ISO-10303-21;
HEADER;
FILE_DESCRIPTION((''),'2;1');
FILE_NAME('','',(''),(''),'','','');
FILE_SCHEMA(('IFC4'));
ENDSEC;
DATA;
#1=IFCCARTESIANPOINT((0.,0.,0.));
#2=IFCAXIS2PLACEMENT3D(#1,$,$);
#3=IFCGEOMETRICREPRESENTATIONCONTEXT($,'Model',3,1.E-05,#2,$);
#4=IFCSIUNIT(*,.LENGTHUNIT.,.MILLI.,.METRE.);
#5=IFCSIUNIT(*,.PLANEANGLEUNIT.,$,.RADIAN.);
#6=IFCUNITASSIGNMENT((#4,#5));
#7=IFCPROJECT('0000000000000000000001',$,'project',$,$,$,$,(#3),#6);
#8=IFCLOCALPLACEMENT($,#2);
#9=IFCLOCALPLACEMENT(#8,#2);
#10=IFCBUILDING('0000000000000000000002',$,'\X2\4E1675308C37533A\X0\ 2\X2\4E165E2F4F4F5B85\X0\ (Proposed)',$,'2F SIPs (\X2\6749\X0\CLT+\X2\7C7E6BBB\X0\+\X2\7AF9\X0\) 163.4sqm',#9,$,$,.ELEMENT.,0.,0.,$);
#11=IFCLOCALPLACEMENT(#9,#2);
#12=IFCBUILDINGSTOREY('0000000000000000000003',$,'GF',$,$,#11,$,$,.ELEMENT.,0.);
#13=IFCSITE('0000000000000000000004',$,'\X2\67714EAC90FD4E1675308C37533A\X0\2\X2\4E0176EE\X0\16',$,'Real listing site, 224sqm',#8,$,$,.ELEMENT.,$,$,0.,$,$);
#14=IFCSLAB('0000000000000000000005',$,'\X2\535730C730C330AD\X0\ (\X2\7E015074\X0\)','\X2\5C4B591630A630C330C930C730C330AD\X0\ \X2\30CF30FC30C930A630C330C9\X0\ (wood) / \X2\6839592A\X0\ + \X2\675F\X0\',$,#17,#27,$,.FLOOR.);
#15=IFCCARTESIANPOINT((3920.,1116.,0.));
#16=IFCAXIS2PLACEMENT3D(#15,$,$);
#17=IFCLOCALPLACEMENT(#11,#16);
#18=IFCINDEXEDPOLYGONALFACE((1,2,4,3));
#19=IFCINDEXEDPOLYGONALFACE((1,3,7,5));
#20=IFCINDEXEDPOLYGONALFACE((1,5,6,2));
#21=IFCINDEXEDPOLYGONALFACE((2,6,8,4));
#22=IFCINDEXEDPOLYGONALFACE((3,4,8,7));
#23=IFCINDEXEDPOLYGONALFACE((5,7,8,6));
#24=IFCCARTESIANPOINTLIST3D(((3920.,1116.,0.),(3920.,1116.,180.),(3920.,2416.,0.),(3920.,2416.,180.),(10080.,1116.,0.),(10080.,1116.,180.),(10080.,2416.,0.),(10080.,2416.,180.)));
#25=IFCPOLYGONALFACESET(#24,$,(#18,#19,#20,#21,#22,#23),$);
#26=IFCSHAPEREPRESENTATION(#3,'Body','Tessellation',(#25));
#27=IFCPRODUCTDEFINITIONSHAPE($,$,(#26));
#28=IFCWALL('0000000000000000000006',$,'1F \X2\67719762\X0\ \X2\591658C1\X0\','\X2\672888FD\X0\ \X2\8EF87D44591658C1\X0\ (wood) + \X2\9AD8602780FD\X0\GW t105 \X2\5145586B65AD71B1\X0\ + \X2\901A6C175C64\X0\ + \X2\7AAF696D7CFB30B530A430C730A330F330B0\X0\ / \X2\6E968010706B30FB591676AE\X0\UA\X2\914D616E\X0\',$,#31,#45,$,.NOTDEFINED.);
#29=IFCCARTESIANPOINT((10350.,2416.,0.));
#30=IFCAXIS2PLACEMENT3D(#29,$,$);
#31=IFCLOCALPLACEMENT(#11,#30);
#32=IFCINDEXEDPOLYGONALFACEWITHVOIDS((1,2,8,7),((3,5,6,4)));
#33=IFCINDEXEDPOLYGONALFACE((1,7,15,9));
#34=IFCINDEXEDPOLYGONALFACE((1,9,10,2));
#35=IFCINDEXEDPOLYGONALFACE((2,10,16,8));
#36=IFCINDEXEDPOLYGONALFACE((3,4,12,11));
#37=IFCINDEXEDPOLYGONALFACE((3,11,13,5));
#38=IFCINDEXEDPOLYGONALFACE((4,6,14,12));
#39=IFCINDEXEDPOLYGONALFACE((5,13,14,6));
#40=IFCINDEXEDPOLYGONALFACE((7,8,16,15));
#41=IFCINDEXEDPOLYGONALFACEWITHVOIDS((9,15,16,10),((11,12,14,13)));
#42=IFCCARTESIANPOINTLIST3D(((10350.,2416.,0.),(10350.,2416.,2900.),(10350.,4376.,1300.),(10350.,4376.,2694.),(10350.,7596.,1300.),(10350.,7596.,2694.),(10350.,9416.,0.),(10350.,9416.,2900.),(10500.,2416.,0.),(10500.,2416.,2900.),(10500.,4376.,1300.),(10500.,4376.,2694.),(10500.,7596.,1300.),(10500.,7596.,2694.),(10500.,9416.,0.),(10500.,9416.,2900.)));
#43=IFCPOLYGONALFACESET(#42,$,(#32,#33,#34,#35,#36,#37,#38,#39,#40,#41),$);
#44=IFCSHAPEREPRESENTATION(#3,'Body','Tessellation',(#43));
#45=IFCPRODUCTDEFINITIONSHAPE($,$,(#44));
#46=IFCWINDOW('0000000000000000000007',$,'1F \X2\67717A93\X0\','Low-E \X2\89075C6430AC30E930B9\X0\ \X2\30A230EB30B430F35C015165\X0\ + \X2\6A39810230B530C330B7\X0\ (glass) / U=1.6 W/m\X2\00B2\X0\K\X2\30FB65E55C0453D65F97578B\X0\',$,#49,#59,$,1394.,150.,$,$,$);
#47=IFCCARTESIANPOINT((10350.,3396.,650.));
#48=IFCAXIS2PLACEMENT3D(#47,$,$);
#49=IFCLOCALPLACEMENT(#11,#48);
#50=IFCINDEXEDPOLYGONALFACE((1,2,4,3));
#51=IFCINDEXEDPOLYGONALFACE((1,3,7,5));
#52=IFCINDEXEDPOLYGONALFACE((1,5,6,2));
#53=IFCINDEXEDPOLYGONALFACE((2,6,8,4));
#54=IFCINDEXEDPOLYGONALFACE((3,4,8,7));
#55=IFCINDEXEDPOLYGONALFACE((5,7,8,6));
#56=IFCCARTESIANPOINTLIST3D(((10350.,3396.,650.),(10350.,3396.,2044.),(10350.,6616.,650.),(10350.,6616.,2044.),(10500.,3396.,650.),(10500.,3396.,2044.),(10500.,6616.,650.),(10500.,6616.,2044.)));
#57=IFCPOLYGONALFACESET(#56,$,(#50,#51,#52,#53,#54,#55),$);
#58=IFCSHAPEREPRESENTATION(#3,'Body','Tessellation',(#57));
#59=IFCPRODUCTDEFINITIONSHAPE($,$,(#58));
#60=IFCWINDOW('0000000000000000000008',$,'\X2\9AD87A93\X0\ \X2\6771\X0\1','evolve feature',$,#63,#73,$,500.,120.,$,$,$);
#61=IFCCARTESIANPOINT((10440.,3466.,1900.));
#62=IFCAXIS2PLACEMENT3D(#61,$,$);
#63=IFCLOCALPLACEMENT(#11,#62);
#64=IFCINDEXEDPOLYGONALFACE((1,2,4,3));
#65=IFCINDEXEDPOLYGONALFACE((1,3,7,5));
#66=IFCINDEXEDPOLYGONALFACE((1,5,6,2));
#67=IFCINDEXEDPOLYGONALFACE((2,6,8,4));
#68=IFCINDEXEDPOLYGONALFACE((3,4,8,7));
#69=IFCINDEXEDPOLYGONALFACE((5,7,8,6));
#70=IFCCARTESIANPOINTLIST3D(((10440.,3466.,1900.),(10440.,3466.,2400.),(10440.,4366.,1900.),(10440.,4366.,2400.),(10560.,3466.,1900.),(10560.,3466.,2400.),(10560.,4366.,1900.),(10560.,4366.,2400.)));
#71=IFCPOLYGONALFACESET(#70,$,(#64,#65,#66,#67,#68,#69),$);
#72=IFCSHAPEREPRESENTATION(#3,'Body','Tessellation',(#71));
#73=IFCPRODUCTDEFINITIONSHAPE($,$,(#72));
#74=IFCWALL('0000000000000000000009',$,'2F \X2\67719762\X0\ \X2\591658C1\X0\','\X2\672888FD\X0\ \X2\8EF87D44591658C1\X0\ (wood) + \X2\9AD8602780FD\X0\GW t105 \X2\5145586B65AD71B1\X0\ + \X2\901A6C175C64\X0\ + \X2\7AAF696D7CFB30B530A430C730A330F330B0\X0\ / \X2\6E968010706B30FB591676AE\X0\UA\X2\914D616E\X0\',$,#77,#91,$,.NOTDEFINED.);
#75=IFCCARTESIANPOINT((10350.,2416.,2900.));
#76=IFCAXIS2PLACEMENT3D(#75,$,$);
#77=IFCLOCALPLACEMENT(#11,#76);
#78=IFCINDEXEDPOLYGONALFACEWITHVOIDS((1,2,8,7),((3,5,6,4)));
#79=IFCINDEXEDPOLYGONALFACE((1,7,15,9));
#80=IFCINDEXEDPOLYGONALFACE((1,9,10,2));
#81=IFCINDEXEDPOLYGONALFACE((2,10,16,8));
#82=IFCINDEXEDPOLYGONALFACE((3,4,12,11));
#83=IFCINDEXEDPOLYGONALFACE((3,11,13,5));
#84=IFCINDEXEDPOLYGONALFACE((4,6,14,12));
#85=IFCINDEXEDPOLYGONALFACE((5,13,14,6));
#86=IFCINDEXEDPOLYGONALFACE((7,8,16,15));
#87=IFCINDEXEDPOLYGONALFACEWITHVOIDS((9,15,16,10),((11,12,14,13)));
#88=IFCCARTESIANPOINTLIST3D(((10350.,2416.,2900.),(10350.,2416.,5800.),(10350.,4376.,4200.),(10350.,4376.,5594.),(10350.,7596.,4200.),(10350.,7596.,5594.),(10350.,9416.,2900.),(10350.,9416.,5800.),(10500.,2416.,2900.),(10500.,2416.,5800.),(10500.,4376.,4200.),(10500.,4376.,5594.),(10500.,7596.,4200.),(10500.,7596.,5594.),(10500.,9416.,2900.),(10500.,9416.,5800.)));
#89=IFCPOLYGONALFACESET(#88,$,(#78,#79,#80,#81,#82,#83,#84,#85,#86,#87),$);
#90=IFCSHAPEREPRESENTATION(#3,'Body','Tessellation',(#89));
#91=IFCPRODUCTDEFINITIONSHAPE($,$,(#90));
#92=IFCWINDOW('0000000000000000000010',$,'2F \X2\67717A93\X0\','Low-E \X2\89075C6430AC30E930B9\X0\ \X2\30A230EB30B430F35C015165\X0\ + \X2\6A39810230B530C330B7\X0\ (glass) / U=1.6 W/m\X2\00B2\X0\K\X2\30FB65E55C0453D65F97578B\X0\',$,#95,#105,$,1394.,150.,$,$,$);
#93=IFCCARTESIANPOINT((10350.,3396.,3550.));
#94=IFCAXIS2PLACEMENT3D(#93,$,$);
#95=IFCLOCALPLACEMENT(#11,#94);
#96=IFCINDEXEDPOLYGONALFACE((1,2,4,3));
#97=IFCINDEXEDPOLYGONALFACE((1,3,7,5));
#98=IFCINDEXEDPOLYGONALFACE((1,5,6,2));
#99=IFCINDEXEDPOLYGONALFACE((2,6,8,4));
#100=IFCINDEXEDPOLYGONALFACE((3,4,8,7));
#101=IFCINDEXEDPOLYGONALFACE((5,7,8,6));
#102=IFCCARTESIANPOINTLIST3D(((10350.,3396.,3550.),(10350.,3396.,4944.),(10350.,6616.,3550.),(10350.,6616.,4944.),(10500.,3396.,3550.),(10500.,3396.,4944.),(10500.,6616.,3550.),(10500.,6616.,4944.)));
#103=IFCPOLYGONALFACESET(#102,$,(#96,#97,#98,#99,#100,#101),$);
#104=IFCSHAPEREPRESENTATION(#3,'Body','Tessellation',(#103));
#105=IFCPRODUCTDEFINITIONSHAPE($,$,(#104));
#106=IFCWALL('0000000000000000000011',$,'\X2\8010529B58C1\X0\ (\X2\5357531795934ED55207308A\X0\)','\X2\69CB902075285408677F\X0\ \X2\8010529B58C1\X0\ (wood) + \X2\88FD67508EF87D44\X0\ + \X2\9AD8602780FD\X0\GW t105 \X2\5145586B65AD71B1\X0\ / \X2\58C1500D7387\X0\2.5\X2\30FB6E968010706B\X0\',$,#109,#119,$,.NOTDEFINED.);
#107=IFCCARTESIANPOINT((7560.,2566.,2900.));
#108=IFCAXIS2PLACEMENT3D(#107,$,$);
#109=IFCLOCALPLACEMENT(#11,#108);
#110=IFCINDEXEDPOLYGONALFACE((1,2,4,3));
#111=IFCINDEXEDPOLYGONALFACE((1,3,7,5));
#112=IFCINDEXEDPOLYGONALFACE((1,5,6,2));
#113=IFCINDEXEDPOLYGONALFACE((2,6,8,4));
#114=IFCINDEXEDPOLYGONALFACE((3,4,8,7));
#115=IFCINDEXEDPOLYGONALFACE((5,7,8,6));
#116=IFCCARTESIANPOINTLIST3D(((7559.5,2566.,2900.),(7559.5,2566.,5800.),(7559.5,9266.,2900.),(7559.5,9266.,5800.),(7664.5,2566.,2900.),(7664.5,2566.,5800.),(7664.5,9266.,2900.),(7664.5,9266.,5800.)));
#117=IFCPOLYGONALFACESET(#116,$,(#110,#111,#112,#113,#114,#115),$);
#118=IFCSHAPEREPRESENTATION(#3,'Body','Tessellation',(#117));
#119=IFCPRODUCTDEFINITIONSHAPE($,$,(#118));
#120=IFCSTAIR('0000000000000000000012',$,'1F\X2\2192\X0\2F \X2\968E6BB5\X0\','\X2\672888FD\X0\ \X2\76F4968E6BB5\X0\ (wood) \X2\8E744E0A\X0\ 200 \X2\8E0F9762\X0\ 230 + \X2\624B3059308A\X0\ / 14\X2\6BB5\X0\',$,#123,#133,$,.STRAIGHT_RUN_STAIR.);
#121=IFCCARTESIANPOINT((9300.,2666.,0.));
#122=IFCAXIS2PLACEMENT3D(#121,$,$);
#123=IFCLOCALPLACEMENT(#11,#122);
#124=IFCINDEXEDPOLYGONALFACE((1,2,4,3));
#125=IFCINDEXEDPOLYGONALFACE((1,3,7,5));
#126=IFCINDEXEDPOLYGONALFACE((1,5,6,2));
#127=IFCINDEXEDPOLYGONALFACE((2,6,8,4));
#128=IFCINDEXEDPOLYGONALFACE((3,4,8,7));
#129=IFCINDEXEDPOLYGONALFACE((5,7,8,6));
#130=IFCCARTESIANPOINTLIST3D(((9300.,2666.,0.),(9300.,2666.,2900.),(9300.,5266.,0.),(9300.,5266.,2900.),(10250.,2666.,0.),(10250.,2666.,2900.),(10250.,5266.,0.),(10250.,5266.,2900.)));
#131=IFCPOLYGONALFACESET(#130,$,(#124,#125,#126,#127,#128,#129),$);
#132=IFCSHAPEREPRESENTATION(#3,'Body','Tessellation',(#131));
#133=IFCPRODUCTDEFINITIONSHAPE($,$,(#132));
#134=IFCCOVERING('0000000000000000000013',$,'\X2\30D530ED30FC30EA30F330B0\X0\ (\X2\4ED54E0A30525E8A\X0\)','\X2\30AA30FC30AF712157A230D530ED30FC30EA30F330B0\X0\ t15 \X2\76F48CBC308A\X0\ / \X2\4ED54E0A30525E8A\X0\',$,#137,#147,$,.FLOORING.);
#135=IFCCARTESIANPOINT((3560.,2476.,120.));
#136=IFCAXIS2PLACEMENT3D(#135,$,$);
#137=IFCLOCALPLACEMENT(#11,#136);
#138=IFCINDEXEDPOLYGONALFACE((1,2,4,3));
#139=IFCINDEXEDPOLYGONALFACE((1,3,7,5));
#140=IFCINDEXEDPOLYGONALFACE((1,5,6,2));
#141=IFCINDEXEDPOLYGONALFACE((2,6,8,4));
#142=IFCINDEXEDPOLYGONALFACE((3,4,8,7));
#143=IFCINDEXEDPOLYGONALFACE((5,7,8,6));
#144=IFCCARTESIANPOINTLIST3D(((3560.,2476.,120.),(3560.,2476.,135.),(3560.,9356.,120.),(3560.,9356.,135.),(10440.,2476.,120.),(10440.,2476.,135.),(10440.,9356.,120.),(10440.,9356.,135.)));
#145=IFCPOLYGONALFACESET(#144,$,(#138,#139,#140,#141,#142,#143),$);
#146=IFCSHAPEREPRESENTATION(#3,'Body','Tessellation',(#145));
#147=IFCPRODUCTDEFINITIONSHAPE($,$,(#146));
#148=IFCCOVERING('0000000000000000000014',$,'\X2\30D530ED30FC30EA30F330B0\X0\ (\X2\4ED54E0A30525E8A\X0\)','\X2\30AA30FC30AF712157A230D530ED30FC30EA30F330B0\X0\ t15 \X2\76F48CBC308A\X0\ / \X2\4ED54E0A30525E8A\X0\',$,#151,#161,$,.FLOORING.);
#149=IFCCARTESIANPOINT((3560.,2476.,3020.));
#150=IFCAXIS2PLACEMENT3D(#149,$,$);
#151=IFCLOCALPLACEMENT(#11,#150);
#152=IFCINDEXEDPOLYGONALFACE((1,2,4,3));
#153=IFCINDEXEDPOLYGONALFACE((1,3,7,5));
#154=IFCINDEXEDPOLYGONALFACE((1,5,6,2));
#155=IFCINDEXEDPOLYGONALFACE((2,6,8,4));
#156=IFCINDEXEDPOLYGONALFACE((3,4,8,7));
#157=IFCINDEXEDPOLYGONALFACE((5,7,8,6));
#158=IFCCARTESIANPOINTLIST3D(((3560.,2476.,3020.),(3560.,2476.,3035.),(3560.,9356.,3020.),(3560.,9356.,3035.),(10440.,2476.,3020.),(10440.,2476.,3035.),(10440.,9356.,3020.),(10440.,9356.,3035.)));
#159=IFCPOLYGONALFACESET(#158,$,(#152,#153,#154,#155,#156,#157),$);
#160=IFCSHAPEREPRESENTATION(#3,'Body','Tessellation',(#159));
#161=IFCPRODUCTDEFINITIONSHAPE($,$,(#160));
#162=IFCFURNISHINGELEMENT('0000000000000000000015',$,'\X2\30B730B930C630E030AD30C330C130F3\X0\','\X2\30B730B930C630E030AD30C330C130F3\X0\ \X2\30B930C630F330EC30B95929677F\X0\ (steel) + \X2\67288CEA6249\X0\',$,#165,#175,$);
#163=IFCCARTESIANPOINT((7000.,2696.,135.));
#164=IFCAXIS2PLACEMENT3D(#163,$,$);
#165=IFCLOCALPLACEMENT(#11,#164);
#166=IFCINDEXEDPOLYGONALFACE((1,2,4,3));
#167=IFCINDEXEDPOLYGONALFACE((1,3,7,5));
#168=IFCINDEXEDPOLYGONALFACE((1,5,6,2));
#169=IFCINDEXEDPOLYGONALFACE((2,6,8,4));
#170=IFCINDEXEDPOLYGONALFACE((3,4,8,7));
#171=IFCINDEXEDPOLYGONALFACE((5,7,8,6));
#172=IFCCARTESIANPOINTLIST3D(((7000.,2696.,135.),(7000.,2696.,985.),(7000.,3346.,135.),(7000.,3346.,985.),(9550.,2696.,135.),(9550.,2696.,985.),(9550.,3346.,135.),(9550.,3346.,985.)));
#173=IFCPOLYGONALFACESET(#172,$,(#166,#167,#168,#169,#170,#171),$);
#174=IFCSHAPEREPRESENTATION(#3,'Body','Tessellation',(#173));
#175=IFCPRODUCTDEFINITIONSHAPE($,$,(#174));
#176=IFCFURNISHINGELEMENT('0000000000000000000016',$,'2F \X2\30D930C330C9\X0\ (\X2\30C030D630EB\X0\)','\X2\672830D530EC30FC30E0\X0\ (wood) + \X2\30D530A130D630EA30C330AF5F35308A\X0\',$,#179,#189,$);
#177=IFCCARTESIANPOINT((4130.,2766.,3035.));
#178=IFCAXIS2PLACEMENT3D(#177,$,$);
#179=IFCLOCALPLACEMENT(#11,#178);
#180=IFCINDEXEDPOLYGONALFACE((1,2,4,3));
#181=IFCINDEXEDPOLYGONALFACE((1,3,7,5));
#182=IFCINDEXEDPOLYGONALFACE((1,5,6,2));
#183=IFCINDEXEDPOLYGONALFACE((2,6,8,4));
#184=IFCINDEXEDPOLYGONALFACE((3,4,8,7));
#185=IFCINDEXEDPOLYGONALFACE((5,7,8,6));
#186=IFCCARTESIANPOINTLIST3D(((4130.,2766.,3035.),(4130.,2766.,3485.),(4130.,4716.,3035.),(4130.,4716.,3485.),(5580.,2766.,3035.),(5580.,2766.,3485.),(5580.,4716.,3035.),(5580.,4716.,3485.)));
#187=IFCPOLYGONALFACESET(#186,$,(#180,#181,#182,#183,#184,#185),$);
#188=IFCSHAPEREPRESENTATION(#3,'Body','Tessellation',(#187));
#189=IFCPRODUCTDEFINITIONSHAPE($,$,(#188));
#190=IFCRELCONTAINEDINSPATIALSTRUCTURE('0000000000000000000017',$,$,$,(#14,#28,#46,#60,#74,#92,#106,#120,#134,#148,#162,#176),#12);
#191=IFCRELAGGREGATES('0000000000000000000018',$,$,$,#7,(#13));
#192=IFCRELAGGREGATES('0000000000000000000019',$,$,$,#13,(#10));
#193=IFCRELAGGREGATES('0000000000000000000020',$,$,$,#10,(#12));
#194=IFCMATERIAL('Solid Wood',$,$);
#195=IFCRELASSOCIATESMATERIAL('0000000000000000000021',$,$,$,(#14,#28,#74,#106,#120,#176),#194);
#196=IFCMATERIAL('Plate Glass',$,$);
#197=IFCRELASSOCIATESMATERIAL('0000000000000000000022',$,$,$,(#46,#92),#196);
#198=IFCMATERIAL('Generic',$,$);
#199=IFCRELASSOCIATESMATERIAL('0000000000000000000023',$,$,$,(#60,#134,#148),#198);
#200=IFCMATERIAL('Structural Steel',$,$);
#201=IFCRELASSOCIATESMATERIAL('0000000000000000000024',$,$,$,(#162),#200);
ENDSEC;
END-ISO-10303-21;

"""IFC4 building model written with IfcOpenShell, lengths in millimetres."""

from ifc_helpers import new_model, si_unit, frame, frame_2d, origin, place, context, project, spatial, rectangle, extrude, material, element, fill, save


model = new_model("IFC4")

# Units and contexts
model_context = context("Model", 3, precision=1e-05, world=origin())
ifc_project = project(units=[si_unit("LENGTHUNIT", "METRE", prefix="MILLI"), si_unit("PLANEANGLEUNIT", "RADIAN")], contexts=[model_context])

# Site, building, storey
site_placement = place(None, origin())
site = spatial("IfcSite", under=ifc_project, at=site_placement, Name="東京都世田谷区2丁目16", ObjectType="Real listing site, 224sqm", CompositionType="ELEMENT", RefElevation=0.0)
building_placement = place(site_placement, origin())
building = spatial("IfcBuilding", under=site, at=building_placement, Name="世田谷区 2世帯住宅 (Proposed)", ObjectType="2F SIPs (杉CLT+籾殻+竹) 163.4sqm", CompositionType="ELEMENT", ElevationOfRefHeight=0.0, ElevationOfTerrain=0.0)
storey_placement = place(building_placement, origin())
storey = spatial("IfcBuildingStorey", under=building, at=storey_placement, Name="GF", CompositionType="ELEMENT", Elevation=0.0)

# Slab
ifc_material_1 = material(Name="Solid Wood")
slab_placement = place(storey_placement, frame((3920.0, 1116.0, 0.0)))
element("IfcSlab", 1, at=slab_placement, inside=storey, material=ifc_material_1, Name="南デッキ (縁側)", Description="屋外ウッドデッキ ハードウッド (wood) / 根太 + 束", PredefinedType="FLOOR", context=model_context, shape_type="SweptSolid", body=[
    extrude(rectangle(XDim=6160.0, YDim=1300.0, at=frame_2d((3080.0, 650.0))), frame((3920.0, 1116.0, 0.0)), (0.0, 0.0, 1.0), 180.0),
])

# Wall, openings, windows
wall_1_placement = place(storey_placement, frame((10350.0, 2416.0, 0.0)))
wall_1 = element("IfcWall", 2, at=wall_1_placement, inside=storey, material=ifc_material_1, Name="1F 東面 外壁", Description="木製 軸組外壁 (wood) + 高性能GW t105 充填断熱 + 通気層 + 窯業系サイディング / 準耐火・外皮UA配慮", PredefinedType="NOTDEFINED", context=model_context, shape_type="SweptSolid", body=[
    extrude(rectangle(XDim=150.0, YDim=7000.0, at=frame_2d((75.0, 3500.0))), frame((10350.0, 2416.0, 0.0)), (0.0, 0.0, 1.0), 2900.0),
])
opening_1_placement = place(storey_placement, frame((10350.0, 3396.0, 650.0)))
opening_1 = element("IfcOpeningElement", 3, at=opening_1_placement, cuts=wall_1, PredefinedType="NOTDEFINED", context=model_context, shape_type="SweptSolid", body=[
    extrude(rectangle(XDim=150.0, YDim=3220.0, at=frame_2d((75.0, 1610.0))), frame((10350.0, 3396.0, 650.0)), (0.0, 0.0, 1.0), 1394.0),
])
opening_2_placement = place(storey_placement, frame((10440.0, 3466.0, 1900.0)))
opening_2 = element("IfcOpeningElement", 4, at=opening_2_placement, cuts=wall_1, PredefinedType="NOTDEFINED", context=model_context, shape_type="SweptSolid", body=[
    extrude(rectangle(XDim=120.0, YDim=900.0, at=frame_2d((60.0, 450.0))), frame((10440.0, 3466.0, 1900.0)), (0.0, 0.0, 1.0), 500.0),
])
ifc_material_2 = material(Name="Plate Glass")
window_1_placement = place(storey_placement, frame((10350.0, 3396.0, 650.0)))
window_1 = element("IfcWindow", 5, at=window_1_placement, inside=storey, material=ifc_material_2, Name="1F 東窓", Description="Low-E 複層ガラス アルゴン封入 + 樹脂サッシ (glass) / U=1.6 W/m²K・日射取得型", OverallHeight=1394.0, OverallWidth=150.0, context=model_context, shape_type="SweptSolid", body=[
    extrude(rectangle(XDim=150.0, YDim=3220.0, at=frame_2d((75.0, 1610.0))), frame((10350.0, 3396.0, 650.0)), (0.0, 0.0, 1.0), 1394.0),
])
fill(opening_1, window_1)
ifc_material_3 = material(Name="Generic")
window_2_placement = place(storey_placement, frame((10440.0, 3466.0, 1900.0)))
window_2 = element("IfcWindow", 6, at=window_2_placement, inside=storey, material=ifc_material_3, Name="高窓 東1", Description="evolve feature", OverallHeight=500.0, OverallWidth=120.0, context=model_context, shape_type="SweptSolid", body=[
    extrude(rectangle(XDim=120.0, YDim=900.0, at=frame_2d((60.0, 450.0))), frame((10440.0, 3466.0, 1900.0)), (0.0, 0.0, 1.0), 500.0),
])
fill(opening_2, window_2)

# Wall, opening, window
wall_2_placement = place(storey_placement, frame((10350.0, 2416.0, 2900.0)))
wall_2 = element("IfcWall", 7, at=wall_2_placement, inside=storey, material=ifc_material_1, Name="2F 東面 外壁", Description="木製 軸組外壁 (wood) + 高性能GW t105 充填断熱 + 通気層 + 窯業系サイディング / 準耐火・外皮UA配慮", PredefinedType="NOTDEFINED", context=model_context, shape_type="SweptSolid", body=[
    extrude(rectangle(XDim=150.0, YDim=7000.0, at=frame_2d((75.0, 3500.0))), frame((10350.0, 2416.0, 2900.0)), (0.0, 0.0, 1.0), 2900.0),
])
opening_3_placement = place(storey_placement, frame((10350.0, 3396.0, 3550.0)))
opening_3 = element("IfcOpeningElement", 8, at=opening_3_placement, cuts=wall_2, PredefinedType="NOTDEFINED", context=model_context, shape_type="SweptSolid", body=[
    extrude(rectangle(XDim=150.0, YDim=3220.0, at=frame_2d((75.0, 1610.0))), frame((10350.0, 3396.0, 3550.0)), (0.0, 0.0, 1.0), 1394.0),
])
window_3_placement = place(storey_placement, frame((10350.0, 3396.0, 3550.0)))
window_3 = element("IfcWindow", 9, at=window_3_placement, inside=storey, material=ifc_material_2, Name="2F 東窓", Description="Low-E 複層ガラス アルゴン封入 + 樹脂サッシ (glass) / U=1.6 W/m²K・日射取得型", OverallHeight=1394.0, OverallWidth=150.0, context=model_context, shape_type="SweptSolid", body=[
    extrude(rectangle(XDim=150.0, YDim=3220.0, at=frame_2d((75.0, 1610.0))), frame((10350.0, 3396.0, 3550.0)), (0.0, 0.0, 1.0), 1394.0),
])
fill(opening_3, window_3)

# Wall
wall_3_placement = place(storey_placement, frame((7560.0, 2566.0, 2900.0)))
element("IfcWall", 10, at=wall_3_placement, inside=storey, material=ifc_material_1, Name="耐力壁 (南北間仕切り)", Description="構造用合板 耐力壁 (wood) + 製材軸組 + 高性能GW t105 充填断熱 / 壁倍率2.5・準耐火", PredefinedType="NOTDEFINED", context=model_context, shape_type="SweptSolid", body=[
    extrude(rectangle(XDim=105.0, YDim=6700.0, at=frame_2d((52.0, 3350.0))), frame((7560.0, 2566.0, 2900.0)), (0.0, 0.0, 1.0), 2900.0),
])

# Stair
stair_placement = place(storey_placement, frame((9300.0, 2666.0, 0.0)))
element("IfcStair", 11, at=stair_placement, inside=storey, material=ifc_material_1, Name="1F→2F 階段", Description="木製 直階段 (wood) 蹴上 200 踏面 230 + 手すり / 14段", PredefinedType="STRAIGHT_RUN_STAIR", context=model_context, shape_type="SweptSolid", body=[
    extrude(rectangle(XDim=950.0, YDim=2600.0, at=frame_2d((475.0, 1300.0))), frame((9300.0, 2666.0, 0.0)), (0.0, 0.0, 1.0), 2900.0),
])

# Coverings
covering_1_placement = place(storey_placement, frame((3560.0, 2476.0, 120.0)))
element("IfcCovering", 12, at=covering_1_placement, inside=storey, material=ifc_material_3, Name="フローリング (仕上げ床)", Description="オーク無垢フローリング t15 直貼り / 仕上げ床", PredefinedType="FLOORING", context=model_context, shape_type="SweptSolid", body=[
    extrude(rectangle(XDim=6880.0, YDim=6880.0, at=frame_2d((3440.0, 3440.0))), frame((3560.0, 2476.0, 120.0)), (0.0, 0.0, 1.0), 15.0),
])
covering_2_placement = place(storey_placement, frame((3560.0, 2476.0, 3020.0)))
element("IfcCovering", 13, at=covering_2_placement, inside=storey, material=ifc_material_3, Name="フローリング (仕上げ床)", Description="オーク無垢フローリング t15 直貼り / 仕上げ床", PredefinedType="FLOORING", context=model_context, shape_type="SweptSolid", body=[
    extrude(rectangle(XDim=6880.0, YDim=6880.0, at=frame_2d((3440.0, 3440.0))), frame((3560.0, 2476.0, 3020.0)), (0.0, 0.0, 1.0), 15.0),
])

# Furnishing elements
ifc_material_4 = material(Name="Structural Steel")
furnishing_1_placement = place(storey_placement, frame((7000.0, 2696.0, 135.0)))
element("IfcFurnishingElement", 14, at=furnishing_1_placement, inside=storey, material=ifc_material_4, Name="システムキッチン", Description="システムキッチン ステンレス天板 (steel) + 木質扉", context=model_context, shape_type="SweptSolid", body=[
    extrude(rectangle(XDim=2550.0, YDim=650.0, at=frame_2d((1275.0, 325.0))), frame((7000.0, 2696.0, 135.0)), (0.0, 0.0, 1.0), 850.0),
])
furnishing_2_placement = place(storey_placement, frame((4130.0, 2766.0, 3035.0)))
element("IfcFurnishingElement", 15, at=furnishing_2_placement, inside=storey, material=ifc_material_1, Name="2F ベッド (ダブル)", Description="木フレーム (wood) + ファブリック張り", context=model_context, shape_type="SweptSolid", body=[
    extrude(rectangle(XDim=1450.0, YDim=1950.0, at=frame_2d((725.0, 975.0))), frame((4130.0, 2766.0, 3035.0)), (0.0, 0.0, 1.0), 450.0),
])

save(model, "model.ifc")
